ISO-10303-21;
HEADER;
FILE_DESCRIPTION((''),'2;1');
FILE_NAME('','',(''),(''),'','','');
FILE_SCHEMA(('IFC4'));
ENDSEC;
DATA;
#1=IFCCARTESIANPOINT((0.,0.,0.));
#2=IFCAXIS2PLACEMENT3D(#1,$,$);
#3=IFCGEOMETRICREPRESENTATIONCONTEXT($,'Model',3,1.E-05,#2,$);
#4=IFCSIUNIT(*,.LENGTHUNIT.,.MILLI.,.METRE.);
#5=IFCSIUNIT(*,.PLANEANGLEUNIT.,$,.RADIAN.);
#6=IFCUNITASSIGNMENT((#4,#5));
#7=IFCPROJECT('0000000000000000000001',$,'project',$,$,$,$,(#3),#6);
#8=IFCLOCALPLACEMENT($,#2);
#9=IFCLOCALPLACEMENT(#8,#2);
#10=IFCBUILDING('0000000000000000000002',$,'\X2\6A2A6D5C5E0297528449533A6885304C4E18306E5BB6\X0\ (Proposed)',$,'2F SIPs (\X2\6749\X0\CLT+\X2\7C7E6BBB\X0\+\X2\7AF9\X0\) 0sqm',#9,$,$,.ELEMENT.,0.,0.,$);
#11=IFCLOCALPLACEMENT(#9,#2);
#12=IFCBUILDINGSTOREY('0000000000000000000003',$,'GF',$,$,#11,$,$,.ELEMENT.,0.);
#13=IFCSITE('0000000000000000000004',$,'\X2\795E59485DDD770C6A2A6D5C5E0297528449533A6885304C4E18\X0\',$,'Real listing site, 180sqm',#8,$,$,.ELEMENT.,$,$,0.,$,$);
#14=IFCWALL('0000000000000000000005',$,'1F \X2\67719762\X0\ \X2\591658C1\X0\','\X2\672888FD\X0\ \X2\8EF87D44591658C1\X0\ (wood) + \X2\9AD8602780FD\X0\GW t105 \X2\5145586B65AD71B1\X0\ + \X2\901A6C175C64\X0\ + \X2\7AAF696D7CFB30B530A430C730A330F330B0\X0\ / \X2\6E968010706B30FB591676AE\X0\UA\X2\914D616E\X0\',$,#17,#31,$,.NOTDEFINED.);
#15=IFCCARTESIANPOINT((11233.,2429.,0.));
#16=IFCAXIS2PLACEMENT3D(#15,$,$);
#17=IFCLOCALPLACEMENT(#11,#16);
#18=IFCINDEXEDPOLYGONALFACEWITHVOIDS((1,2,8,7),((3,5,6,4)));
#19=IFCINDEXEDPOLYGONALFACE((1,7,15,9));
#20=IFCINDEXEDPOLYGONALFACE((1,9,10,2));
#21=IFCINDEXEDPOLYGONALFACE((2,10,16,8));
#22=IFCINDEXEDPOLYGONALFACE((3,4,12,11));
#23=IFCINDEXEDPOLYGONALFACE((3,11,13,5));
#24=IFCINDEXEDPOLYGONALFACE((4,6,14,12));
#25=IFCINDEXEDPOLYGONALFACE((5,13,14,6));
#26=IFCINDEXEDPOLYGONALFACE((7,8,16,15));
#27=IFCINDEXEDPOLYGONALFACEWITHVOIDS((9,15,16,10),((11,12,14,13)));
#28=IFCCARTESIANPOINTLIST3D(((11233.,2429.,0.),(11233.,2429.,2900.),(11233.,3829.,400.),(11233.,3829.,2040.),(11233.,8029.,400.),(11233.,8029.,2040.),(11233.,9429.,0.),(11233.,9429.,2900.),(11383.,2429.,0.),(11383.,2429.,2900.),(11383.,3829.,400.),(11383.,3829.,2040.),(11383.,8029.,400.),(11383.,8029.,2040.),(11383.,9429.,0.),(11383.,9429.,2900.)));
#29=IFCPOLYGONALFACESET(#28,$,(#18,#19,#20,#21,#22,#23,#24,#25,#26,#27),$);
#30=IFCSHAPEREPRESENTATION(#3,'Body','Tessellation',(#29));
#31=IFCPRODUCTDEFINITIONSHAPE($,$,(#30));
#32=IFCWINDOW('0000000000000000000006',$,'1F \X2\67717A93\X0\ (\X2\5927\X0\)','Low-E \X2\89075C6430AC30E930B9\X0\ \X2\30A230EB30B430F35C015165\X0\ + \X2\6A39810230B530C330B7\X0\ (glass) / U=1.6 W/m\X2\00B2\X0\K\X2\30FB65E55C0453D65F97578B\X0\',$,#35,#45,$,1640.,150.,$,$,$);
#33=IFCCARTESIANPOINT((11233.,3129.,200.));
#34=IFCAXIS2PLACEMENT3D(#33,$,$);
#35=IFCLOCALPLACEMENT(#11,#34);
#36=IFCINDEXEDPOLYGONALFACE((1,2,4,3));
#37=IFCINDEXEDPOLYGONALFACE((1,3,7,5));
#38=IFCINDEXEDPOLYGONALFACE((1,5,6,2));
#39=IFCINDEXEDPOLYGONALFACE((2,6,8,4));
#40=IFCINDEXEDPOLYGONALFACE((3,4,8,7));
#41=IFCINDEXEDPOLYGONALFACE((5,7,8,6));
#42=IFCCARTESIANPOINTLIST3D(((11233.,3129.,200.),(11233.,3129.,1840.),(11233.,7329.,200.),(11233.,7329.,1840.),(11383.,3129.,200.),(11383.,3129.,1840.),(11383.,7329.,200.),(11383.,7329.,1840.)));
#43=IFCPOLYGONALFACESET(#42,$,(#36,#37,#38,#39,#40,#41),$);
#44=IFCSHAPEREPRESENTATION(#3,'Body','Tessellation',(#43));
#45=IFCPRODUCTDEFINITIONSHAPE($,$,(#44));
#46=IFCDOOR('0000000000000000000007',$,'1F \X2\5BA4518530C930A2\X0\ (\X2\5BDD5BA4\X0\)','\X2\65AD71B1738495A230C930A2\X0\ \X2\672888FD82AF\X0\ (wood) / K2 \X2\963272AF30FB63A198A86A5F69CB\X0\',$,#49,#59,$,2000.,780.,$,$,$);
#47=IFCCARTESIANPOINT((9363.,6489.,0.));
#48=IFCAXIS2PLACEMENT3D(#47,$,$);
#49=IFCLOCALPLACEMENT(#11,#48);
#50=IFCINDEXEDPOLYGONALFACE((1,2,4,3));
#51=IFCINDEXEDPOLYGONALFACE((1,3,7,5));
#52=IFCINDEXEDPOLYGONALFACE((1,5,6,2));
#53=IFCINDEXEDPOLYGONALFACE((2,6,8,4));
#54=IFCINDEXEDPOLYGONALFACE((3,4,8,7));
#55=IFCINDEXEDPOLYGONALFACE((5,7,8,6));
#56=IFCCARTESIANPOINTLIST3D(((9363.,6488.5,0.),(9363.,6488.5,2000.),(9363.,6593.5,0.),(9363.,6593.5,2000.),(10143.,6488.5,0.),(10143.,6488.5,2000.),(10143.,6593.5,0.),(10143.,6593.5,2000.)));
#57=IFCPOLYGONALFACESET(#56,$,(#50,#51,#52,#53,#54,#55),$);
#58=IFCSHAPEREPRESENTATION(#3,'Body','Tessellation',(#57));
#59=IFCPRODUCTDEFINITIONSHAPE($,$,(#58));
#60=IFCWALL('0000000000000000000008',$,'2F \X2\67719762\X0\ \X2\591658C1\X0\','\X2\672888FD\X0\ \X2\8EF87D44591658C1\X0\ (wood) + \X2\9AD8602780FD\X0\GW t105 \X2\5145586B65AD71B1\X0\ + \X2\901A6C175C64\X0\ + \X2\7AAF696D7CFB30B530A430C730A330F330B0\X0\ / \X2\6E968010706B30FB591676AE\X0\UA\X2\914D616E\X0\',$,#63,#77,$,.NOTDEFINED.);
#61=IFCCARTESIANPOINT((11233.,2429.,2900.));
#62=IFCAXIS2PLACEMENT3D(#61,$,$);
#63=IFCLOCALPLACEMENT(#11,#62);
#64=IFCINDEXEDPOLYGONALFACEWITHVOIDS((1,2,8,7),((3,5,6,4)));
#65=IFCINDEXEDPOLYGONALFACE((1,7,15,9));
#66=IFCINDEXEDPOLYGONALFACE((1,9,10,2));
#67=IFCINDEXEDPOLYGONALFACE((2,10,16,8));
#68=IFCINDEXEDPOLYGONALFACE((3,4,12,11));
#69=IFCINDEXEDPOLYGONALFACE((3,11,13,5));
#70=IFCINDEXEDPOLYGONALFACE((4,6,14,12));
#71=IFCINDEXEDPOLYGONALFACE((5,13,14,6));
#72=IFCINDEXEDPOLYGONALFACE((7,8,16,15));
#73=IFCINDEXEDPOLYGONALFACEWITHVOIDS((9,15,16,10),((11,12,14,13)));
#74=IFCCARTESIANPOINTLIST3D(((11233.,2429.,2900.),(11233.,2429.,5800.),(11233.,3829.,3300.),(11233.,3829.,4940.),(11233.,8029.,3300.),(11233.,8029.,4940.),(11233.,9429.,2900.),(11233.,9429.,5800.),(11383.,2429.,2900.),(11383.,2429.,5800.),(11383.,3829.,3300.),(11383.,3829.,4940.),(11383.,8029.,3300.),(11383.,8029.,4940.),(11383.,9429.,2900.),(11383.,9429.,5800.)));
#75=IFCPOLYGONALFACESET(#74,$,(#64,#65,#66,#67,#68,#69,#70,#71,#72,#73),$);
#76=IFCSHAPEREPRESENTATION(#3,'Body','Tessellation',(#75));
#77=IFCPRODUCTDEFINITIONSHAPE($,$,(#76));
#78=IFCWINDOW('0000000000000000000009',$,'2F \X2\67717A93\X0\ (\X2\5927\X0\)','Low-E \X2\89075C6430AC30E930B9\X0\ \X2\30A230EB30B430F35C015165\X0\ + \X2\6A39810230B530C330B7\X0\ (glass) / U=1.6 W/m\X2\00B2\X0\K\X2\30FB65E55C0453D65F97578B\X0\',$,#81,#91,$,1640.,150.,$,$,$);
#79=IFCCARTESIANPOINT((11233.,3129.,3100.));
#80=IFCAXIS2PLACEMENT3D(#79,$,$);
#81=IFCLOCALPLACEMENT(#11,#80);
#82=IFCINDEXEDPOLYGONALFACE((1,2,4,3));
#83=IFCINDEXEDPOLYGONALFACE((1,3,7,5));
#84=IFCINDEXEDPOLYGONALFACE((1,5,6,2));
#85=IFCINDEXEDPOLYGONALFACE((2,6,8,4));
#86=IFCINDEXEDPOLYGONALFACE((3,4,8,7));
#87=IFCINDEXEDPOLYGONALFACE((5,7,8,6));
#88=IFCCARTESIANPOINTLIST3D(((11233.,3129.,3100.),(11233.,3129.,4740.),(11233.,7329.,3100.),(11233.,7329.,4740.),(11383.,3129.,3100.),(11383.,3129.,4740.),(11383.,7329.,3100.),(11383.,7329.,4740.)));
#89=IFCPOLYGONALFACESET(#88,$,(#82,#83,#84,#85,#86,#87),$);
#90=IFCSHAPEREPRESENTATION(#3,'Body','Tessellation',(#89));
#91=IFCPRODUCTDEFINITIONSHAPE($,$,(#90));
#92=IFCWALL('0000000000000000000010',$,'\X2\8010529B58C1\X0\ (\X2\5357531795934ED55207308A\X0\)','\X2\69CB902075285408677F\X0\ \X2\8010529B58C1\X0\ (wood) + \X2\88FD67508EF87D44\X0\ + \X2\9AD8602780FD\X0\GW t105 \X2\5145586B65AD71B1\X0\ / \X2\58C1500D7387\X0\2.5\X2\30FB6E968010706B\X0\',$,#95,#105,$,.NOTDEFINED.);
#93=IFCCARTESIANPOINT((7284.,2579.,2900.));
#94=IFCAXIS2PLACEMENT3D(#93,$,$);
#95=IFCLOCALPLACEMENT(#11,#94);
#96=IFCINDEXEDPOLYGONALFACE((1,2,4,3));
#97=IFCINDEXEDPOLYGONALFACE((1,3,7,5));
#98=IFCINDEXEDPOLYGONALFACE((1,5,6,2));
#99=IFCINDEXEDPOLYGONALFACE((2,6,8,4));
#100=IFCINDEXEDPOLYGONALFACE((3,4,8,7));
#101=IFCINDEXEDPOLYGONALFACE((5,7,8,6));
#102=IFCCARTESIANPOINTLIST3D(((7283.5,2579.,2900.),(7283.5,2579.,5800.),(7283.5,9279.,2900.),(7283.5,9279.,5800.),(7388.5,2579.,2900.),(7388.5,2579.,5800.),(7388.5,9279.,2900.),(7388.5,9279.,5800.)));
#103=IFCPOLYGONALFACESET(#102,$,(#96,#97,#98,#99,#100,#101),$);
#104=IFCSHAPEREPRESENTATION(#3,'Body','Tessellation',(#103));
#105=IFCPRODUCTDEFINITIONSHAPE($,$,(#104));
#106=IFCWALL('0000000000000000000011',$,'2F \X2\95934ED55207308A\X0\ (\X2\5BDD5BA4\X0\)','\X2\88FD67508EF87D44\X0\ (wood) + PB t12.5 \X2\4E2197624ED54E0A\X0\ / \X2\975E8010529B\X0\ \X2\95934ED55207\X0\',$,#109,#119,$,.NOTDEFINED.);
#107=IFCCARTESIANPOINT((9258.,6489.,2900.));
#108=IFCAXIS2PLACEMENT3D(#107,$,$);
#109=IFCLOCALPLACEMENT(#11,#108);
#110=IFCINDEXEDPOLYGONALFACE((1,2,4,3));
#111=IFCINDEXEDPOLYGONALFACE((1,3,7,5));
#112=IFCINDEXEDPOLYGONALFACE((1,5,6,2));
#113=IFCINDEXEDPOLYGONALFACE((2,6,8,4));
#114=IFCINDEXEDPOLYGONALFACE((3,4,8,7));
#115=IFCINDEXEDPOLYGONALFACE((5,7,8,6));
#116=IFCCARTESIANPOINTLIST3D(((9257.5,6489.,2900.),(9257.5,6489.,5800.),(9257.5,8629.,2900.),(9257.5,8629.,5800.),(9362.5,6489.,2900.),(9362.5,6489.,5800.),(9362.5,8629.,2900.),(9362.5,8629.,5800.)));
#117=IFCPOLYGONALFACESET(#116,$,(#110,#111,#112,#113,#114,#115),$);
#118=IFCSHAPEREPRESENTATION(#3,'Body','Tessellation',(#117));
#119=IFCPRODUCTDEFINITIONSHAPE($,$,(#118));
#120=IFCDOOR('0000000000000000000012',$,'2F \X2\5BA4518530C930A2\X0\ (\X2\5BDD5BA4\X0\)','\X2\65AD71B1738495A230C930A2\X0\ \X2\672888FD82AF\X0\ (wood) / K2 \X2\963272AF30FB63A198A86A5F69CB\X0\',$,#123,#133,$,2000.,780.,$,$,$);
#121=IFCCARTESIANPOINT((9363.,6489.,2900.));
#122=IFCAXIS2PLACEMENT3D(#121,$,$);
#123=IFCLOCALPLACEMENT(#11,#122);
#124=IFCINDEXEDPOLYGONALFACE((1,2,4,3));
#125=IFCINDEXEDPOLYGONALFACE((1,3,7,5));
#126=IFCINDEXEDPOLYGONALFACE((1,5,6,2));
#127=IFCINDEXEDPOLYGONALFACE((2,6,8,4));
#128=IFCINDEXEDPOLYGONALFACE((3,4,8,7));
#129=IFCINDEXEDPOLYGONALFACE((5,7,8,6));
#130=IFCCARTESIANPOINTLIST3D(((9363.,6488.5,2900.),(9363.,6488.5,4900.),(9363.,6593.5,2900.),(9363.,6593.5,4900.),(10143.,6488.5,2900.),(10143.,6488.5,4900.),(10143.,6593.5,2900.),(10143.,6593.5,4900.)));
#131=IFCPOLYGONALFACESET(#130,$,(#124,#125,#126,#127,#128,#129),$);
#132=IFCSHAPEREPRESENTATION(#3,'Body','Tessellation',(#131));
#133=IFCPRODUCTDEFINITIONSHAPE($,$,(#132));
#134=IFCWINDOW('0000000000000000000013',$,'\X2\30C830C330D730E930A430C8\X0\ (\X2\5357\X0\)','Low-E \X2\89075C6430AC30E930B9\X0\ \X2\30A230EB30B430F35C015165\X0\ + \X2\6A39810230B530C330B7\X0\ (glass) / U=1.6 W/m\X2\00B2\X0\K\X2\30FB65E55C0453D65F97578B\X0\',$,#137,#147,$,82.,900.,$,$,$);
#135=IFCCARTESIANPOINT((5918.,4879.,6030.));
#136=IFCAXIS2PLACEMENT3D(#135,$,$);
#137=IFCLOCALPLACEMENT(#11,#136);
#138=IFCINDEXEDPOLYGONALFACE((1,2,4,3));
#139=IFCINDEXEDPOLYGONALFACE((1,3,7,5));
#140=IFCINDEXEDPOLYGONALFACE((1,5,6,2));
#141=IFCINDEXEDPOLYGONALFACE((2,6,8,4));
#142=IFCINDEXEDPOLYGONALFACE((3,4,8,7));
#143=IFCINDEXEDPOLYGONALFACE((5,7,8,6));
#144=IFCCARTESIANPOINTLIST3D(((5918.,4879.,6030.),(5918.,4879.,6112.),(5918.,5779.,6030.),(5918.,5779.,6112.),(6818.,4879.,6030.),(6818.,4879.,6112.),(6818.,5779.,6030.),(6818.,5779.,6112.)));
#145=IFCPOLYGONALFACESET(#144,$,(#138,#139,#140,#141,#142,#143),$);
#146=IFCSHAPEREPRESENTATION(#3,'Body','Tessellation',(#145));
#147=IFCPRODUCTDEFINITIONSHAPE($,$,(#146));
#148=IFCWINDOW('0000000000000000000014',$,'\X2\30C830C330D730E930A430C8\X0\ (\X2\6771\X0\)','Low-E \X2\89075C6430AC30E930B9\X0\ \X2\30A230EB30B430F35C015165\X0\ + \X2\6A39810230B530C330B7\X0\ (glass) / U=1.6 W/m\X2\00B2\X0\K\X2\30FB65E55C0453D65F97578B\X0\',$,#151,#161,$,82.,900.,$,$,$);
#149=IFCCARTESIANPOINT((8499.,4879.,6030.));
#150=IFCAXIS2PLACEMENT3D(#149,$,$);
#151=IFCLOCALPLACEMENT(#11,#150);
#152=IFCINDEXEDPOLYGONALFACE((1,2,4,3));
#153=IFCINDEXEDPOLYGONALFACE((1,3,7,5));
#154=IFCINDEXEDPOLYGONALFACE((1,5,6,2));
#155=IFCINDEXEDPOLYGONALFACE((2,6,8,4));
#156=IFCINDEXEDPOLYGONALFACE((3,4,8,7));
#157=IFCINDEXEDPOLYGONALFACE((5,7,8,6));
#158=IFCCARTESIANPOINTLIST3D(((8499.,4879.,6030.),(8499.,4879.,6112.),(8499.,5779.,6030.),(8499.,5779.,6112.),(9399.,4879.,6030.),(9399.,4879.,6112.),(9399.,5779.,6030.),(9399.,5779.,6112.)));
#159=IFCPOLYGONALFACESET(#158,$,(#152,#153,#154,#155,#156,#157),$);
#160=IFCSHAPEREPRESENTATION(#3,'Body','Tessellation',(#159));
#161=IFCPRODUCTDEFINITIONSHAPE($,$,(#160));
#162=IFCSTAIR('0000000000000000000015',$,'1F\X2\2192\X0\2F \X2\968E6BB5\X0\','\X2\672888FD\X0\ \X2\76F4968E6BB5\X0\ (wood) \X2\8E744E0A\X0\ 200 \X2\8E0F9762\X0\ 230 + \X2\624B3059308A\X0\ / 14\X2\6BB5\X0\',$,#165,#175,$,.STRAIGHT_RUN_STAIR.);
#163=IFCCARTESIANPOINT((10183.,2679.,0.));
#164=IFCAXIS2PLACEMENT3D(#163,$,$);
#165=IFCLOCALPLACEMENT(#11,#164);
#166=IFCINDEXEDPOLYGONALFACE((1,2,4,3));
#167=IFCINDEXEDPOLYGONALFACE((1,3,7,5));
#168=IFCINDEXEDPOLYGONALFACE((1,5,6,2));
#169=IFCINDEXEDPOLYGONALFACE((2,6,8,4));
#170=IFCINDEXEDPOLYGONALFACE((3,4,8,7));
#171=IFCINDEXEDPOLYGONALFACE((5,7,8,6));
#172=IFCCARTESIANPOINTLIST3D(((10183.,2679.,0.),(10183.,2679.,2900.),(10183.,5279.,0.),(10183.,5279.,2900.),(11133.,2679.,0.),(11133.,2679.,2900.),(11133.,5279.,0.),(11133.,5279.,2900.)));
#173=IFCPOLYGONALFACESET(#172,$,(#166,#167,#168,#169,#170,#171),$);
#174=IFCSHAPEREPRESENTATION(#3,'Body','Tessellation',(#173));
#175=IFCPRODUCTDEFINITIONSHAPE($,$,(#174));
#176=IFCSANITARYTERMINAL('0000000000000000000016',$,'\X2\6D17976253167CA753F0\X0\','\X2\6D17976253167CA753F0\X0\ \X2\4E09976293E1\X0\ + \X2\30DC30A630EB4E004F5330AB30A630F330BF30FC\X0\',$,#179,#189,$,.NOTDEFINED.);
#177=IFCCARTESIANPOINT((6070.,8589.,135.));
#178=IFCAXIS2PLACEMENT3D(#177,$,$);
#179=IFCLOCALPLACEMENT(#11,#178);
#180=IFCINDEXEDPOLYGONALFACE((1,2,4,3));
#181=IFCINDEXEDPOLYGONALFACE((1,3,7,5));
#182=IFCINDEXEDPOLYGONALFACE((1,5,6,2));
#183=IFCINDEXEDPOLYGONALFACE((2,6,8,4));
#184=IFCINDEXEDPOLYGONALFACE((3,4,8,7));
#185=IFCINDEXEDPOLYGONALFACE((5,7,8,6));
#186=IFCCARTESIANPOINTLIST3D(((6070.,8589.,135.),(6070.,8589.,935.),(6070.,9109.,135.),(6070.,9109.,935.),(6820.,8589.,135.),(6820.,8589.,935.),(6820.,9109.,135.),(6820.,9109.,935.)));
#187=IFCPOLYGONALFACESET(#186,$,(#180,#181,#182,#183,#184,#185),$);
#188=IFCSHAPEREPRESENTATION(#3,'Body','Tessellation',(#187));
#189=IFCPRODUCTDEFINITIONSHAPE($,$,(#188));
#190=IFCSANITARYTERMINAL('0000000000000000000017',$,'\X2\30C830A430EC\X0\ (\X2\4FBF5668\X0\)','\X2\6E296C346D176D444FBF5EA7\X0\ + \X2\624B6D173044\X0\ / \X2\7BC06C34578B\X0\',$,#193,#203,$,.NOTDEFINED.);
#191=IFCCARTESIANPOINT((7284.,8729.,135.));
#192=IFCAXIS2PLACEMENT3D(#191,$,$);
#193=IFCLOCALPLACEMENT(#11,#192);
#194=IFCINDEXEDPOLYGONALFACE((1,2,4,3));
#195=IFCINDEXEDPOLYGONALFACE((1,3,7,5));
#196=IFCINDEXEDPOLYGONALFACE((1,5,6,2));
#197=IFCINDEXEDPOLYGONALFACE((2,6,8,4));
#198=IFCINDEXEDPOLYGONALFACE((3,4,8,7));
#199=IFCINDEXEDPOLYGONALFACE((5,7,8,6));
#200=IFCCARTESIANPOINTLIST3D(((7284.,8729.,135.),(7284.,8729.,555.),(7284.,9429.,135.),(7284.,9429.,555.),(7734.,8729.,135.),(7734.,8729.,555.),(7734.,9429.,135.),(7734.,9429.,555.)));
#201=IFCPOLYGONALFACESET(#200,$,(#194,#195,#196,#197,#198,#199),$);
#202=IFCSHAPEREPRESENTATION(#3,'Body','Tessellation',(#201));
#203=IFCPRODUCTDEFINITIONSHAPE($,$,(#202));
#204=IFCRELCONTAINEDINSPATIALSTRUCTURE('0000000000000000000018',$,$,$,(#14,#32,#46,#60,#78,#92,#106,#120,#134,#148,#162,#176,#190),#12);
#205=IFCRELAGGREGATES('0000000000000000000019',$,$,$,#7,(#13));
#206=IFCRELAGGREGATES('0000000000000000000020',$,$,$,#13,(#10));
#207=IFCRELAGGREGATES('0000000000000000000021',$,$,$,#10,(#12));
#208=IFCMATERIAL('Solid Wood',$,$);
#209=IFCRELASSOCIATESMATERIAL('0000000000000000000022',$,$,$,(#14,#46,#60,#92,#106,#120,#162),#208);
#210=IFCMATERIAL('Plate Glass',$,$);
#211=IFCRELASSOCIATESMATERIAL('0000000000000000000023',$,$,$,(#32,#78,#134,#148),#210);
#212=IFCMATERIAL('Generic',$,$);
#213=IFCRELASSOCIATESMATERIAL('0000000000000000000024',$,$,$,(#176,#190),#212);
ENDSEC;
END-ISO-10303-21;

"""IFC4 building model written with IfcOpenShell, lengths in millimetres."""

from ifc_helpers import new_model, si_unit, frame, frame_2d, origin, place, context, project, spatial, rectangle, extrude, material, element, fill, save


model = new_model("IFC4")

# Units and contexts
model_context = context("Model", 3, precision=1e-05, world=origin())
ifc_project = project(units=[si_unit("LENGTHUNIT", "METRE", prefix="MILLI"), si_unit("PLANEANGLEUNIT", "RADIAN")], contexts=[model_context])

# Site, building, storey
site_placement = place(None, origin())
site = spatial("IfcSite", under=ifc_project, at=site_placement, Name="神奈川県横浜市青葉区梅が丘", ObjectType="Real listing site, 180sqm", CompositionType="ELEMENT", RefElevation=0.0)
building_placement = place(site_placement, origin())
building = spatial("IfcBuilding", under=site, at=building_placement, Name="横浜市青葉区梅が丘の家 (Proposed)", ObjectType="2F SIPs (杉CLT+籾殻+竹) 0sqm", CompositionType="ELEMENT", ElevationOfRefHeight=0.0, ElevationOfTerrain=0.0)
storey_placement = place(building_placement, origin())
storey = spatial("IfcBuildingStorey", under=building, at=storey_placement, Name="GF", CompositionType="ELEMENT", Elevation=0.0)

# Wall, opening, window
ifc_material_1 = material(Name="Solid Wood")
wall_1_placement = place(storey_placement, frame((11233.0, 2429.0, 0.0)))
wall_1 = element("IfcWall", 1, at=wall_1_placement, inside=storey, material=ifc_material_1, Name="1F 東面 外壁", Description="木製 軸組外壁 (wood) + 高性能GW t105 充填断熱 + 通気層 + 窯業系サイディング / 準耐火・外皮UA配慮", PredefinedType="NOTDEFINED", context=model_context, shape_type="SweptSolid", body=[
    extrude(rectangle(XDim=150.0, YDim=7000.0, at=frame_2d((75.0, 3500.0))), frame((11233.0, 2429.0, 0.0)), (0.0, 0.0, 1.0), 2900.0),
])
opening_1_placement = place(storey_placement, frame((11233.0, 3129.0, 200.0)))
opening_1 = element("IfcOpeningElement", 2, at=opening_1_placement, cuts=wall_1, PredefinedType="NOTDEFINED", context=model_context, shape_type="SweptSolid", body=[
    extrude(rectangle(XDim=150.0, YDim=4200.0, at=frame_2d((75.0, 2100.0))), frame((11233.0, 3129.0, 200.0)), (0.0, 0.0, 1.0), 1640.0),
])
ifc_material_2 = material(Name="Plate Glass")
window_1_placement = place(storey_placement, frame((11233.0, 3129.0, 200.0)))
window_1 = element("IfcWindow", 3, at=window_1_placement, inside=storey, material=ifc_material_2, Name="1F 東窓 (大)", Description="Low-E 複層ガラス アルゴン封入 + 樹脂サッシ (glass) / U=1.6 W/m²K・日射取得型", OverallHeight=1640.0, OverallWidth=150.0, context=model_context, shape_type="SweptSolid", body=[
    extrude(rectangle(XDim=150.0, YDim=4200.0, at=frame_2d((75.0, 2100.0))), frame((11233.0, 3129.0, 200.0)), (0.0, 0.0, 1.0), 1640.0),
])
fill(opening_1, window_1)

# Door
door_1_placement = place(storey_placement, frame((9363.0, 6489.0, 0.0)))
element("IfcDoor", 4, at=door_1_placement, inside=storey, material=ifc_material_1, Name="1F 室内ドア (寝室)", Description="断熱玄関ドア 木製芯 (wood) / K2 防犯・採風機構", OverallHeight=2000.0, OverallWidth=780.0, context=model_context, shape_type="SweptSolid", body=[
    extrude(rectangle(XDim=780.0, YDim=105.0, at=frame_2d((390.0, 52.0))), frame((9363.0, 6489.0, 0.0)), (0.0, 0.0, 1.0), 2000.0),
])

# Wall, opening, window
wall_2_placement = place(storey_placement, frame((11233.0, 2429.0, 2900.0)))
wall_2 = element("IfcWall", 5, at=wall_2_placement, inside=storey, material=ifc_material_1, Name="2F 東面 外壁", Description="木製 軸組外壁 (wood) + 高性能GW t105 充填断熱 + 通気層 + 窯業系サイディング / 準耐火・外皮UA配慮", PredefinedType="NOTDEFINED", context=model_context, shape_type="SweptSolid", body=[
    extrude(rectangle(XDim=150.0, YDim=7000.0, at=frame_2d((75.0, 3500.0))), frame((11233.0, 2429.0, 2900.0)), (0.0, 0.0, 1.0), 2900.0),
])
opening_2_placement = place(storey_placement, frame((11233.0, 3129.0, 3100.0)))
opening_2 = element("IfcOpeningElement", 6, at=opening_2_placement, cuts=wall_2, PredefinedType="NOTDEFINED", context=model_context, shape_type="SweptSolid", body=[
    extrude(rectangle(XDim=150.0, YDim=4200.0, at=frame_2d((75.0, 2100.0))), frame((11233.0, 3129.0, 3100.0)), (0.0, 0.0, 1.0), 1640.0),
])
window_2_placement = place(storey_placement, frame((11233.0, 3129.0, 3100.0)))
window_2 = element("IfcWindow", 7, at=window_2_placement, inside=storey, material=ifc_material_2, Name="2F 東窓 (大)", Description="Low-E 複層ガラス アルゴン封入 + 樹脂サッシ (glass) / U=1.6 W/m²K・日射取得型", OverallHeight=1640.0, OverallWidth=150.0, context=model_context, shape_type="SweptSolid", body=[
    extrude(rectangle(XDim=150.0, YDim=4200.0, at=frame_2d((75.0, 2100.0))), frame((11233.0, 3129.0, 3100.0)), (0.0, 0.0, 1.0), 1640.0),
])
fill(opening_2, window_2)

# Walls
wall_3_placement = place(storey_placement, frame((7284.0, 2579.0, 2900.0)))
element("IfcWall", 8, at=wall_3_placement, inside=storey, material=ifc_material_1, Name="耐力壁 (南北間仕切り)", Description="構造用合板 耐力壁 (wood) + 製材軸組 + 高性能GW t105 充填断熱 / 壁倍率2.5・準耐火", PredefinedType="NOTDEFINED", context=model_context, shape_type="SweptSolid", body=[
    extrude(rectangle(XDim=105.0, YDim=6700.0, at=frame_2d((52.0, 3350.0))), frame((7284.0, 2579.0, 2900.0)), (0.0, 0.0, 1.0), 2900.0),
])
wall_4_placement = place(storey_placement, frame((9258.0, 6489.0, 2900.0)))
element("IfcWall", 9, at=wall_4_placement, inside=storey, material=ifc_material_1, Name="2F 間仕切り (寝室)", Description="製材軸組 (wood) + PB t12.5 両面仕上 / 非耐力 間仕切", PredefinedType="NOTDEFINED", context=model_context, shape_type="SweptSolid", body=[
    extrude(rectangle(XDim=105.0, YDim=2140.0, at=frame_2d((52.0, 1070.0))), frame((9258.0, 6489.0, 2900.0)), (0.0, 0.0, 1.0), 2900.0),
])

# Door
door_2_placement = place(storey_placement, frame((9363.0, 6489.0, 2900.0)))
element("IfcDoor", 10, at=door_2_placement, inside=storey, material=ifc_material_1, Name="2F 室内ドア (寝室)", Description="断熱玄関ドア 木製芯 (wood) / K2 防犯・採風機構", OverallHeight=2000.0, OverallWidth=780.0, context=model_context, shape_type="SweptSolid", body=[
    extrude(rectangle(XDim=780.0, YDim=105.0, at=frame_2d((390.0, 52.0))), frame((9363.0, 6489.0, 2900.0)), (0.0, 0.0, 1.0), 2000.0),
])

# Windows
window_3_placement = place(storey_placement, frame((5918.0, 4879.0, 6030.0)))
element("IfcWindow", 11, at=window_3_placement, inside=storey, material=ifc_material_2, Name="トップライト (南)", Description="Low-E 複層ガラス アルゴン封入 + 樹脂サッシ (glass) / U=1.6 W/m²K・日射取得型", OverallHeight=82.0, OverallWidth=900.0, context=model_context, shape_type="SweptSolid", body=[
    extrude(rectangle(XDim=900.0, YDim=900.0, at=frame_2d((450.0, 450.0))), frame((5918.0, 4879.0, 6030.0)), (0.0, 0.0, 1.0), 82.0),
])
window_4_placement = place(storey_placement, frame((8499.0, 4879.0, 6030.0)))
element("IfcWindow", 12, at=window_4_placement, inside=storey, material=ifc_material_2, Name="トップライト (東)", Description="Low-E 複層ガラス アルゴン封入 + 樹脂サッシ (glass) / U=1.6 W/m²K・日射取得型", OverallHeight=82.0, OverallWidth=900.0, context=model_context, shape_type="SweptSolid", body=[
    extrude(rectangle(XDim=900.0, YDim=900.0, at=frame_2d((450.0, 450.0))), frame((8499.0, 4879.0, 6030.0)), (0.0, 0.0, 1.0), 82.0),
])

# Stair
stair_placement = place(storey_placement, frame((10183.0, 2679.0, 0.0)))
element("IfcStair", 13, at=stair_placement, inside=storey, material=ifc_material_1, Name="1F→2F 階段", Description="木製 直階段 (wood) 蹴上 200 踏面 230 + 手すり / 14段", PredefinedType="STRAIGHT_RUN_STAIR", context=model_context, shape_type="SweptSolid", body=[
    extrude(rectangle(XDim=950.0, YDim=2600.0, at=frame_2d((475.0, 1300.0))), frame((10183.0, 2679.0, 0.0)), (0.0, 0.0, 1.0), 2900.0),
])

# Sanitary terminals
ifc_material_3 = material(Name="Generic")
sanitary_terminal_1_placement = place(storey_placement, frame((6070.0, 8589.0, 135.0)))
element("IfcSanitaryTerminal", 14, at=sanitary_terminal_1_placement, inside=storey, material=ifc_material_3, Name="洗面化粧台", Description="洗面化粧台 三面鏡 + ボウル一体カウンター", PredefinedType="NOTDEFINED", context=model_context, shape_type="SweptSolid", body=[
    extrude(rectangle(XDim=750.0, YDim=520.0, at=frame_2d((375.0, 260.0))), frame((6070.0, 8589.0, 135.0)), (0.0, 0.0, 1.0), 800.0),
])
sanitary_terminal_2_placement = place(storey_placement, frame((7284.0, 8729.0, 135.0)))
element("IfcSanitaryTerminal", 15, at=sanitary_terminal_2_placement, inside=storey, material=ifc_material_3, Name="トイレ (便器)", Description="温水洗浄便座 + 手洗い / 節水型", PredefinedType="NOTDEFINED", context=model_context, shape_type="SweptSolid", body=[
    extrude(rectangle(XDim=450.0, YDim=700.0, at=frame_2d((225.0, 350.0))), frame((7284.0, 8729.0, 135.0)), (0.0, 0.0, 1.0), 420.0),
])

save(model, "model.ifc")
